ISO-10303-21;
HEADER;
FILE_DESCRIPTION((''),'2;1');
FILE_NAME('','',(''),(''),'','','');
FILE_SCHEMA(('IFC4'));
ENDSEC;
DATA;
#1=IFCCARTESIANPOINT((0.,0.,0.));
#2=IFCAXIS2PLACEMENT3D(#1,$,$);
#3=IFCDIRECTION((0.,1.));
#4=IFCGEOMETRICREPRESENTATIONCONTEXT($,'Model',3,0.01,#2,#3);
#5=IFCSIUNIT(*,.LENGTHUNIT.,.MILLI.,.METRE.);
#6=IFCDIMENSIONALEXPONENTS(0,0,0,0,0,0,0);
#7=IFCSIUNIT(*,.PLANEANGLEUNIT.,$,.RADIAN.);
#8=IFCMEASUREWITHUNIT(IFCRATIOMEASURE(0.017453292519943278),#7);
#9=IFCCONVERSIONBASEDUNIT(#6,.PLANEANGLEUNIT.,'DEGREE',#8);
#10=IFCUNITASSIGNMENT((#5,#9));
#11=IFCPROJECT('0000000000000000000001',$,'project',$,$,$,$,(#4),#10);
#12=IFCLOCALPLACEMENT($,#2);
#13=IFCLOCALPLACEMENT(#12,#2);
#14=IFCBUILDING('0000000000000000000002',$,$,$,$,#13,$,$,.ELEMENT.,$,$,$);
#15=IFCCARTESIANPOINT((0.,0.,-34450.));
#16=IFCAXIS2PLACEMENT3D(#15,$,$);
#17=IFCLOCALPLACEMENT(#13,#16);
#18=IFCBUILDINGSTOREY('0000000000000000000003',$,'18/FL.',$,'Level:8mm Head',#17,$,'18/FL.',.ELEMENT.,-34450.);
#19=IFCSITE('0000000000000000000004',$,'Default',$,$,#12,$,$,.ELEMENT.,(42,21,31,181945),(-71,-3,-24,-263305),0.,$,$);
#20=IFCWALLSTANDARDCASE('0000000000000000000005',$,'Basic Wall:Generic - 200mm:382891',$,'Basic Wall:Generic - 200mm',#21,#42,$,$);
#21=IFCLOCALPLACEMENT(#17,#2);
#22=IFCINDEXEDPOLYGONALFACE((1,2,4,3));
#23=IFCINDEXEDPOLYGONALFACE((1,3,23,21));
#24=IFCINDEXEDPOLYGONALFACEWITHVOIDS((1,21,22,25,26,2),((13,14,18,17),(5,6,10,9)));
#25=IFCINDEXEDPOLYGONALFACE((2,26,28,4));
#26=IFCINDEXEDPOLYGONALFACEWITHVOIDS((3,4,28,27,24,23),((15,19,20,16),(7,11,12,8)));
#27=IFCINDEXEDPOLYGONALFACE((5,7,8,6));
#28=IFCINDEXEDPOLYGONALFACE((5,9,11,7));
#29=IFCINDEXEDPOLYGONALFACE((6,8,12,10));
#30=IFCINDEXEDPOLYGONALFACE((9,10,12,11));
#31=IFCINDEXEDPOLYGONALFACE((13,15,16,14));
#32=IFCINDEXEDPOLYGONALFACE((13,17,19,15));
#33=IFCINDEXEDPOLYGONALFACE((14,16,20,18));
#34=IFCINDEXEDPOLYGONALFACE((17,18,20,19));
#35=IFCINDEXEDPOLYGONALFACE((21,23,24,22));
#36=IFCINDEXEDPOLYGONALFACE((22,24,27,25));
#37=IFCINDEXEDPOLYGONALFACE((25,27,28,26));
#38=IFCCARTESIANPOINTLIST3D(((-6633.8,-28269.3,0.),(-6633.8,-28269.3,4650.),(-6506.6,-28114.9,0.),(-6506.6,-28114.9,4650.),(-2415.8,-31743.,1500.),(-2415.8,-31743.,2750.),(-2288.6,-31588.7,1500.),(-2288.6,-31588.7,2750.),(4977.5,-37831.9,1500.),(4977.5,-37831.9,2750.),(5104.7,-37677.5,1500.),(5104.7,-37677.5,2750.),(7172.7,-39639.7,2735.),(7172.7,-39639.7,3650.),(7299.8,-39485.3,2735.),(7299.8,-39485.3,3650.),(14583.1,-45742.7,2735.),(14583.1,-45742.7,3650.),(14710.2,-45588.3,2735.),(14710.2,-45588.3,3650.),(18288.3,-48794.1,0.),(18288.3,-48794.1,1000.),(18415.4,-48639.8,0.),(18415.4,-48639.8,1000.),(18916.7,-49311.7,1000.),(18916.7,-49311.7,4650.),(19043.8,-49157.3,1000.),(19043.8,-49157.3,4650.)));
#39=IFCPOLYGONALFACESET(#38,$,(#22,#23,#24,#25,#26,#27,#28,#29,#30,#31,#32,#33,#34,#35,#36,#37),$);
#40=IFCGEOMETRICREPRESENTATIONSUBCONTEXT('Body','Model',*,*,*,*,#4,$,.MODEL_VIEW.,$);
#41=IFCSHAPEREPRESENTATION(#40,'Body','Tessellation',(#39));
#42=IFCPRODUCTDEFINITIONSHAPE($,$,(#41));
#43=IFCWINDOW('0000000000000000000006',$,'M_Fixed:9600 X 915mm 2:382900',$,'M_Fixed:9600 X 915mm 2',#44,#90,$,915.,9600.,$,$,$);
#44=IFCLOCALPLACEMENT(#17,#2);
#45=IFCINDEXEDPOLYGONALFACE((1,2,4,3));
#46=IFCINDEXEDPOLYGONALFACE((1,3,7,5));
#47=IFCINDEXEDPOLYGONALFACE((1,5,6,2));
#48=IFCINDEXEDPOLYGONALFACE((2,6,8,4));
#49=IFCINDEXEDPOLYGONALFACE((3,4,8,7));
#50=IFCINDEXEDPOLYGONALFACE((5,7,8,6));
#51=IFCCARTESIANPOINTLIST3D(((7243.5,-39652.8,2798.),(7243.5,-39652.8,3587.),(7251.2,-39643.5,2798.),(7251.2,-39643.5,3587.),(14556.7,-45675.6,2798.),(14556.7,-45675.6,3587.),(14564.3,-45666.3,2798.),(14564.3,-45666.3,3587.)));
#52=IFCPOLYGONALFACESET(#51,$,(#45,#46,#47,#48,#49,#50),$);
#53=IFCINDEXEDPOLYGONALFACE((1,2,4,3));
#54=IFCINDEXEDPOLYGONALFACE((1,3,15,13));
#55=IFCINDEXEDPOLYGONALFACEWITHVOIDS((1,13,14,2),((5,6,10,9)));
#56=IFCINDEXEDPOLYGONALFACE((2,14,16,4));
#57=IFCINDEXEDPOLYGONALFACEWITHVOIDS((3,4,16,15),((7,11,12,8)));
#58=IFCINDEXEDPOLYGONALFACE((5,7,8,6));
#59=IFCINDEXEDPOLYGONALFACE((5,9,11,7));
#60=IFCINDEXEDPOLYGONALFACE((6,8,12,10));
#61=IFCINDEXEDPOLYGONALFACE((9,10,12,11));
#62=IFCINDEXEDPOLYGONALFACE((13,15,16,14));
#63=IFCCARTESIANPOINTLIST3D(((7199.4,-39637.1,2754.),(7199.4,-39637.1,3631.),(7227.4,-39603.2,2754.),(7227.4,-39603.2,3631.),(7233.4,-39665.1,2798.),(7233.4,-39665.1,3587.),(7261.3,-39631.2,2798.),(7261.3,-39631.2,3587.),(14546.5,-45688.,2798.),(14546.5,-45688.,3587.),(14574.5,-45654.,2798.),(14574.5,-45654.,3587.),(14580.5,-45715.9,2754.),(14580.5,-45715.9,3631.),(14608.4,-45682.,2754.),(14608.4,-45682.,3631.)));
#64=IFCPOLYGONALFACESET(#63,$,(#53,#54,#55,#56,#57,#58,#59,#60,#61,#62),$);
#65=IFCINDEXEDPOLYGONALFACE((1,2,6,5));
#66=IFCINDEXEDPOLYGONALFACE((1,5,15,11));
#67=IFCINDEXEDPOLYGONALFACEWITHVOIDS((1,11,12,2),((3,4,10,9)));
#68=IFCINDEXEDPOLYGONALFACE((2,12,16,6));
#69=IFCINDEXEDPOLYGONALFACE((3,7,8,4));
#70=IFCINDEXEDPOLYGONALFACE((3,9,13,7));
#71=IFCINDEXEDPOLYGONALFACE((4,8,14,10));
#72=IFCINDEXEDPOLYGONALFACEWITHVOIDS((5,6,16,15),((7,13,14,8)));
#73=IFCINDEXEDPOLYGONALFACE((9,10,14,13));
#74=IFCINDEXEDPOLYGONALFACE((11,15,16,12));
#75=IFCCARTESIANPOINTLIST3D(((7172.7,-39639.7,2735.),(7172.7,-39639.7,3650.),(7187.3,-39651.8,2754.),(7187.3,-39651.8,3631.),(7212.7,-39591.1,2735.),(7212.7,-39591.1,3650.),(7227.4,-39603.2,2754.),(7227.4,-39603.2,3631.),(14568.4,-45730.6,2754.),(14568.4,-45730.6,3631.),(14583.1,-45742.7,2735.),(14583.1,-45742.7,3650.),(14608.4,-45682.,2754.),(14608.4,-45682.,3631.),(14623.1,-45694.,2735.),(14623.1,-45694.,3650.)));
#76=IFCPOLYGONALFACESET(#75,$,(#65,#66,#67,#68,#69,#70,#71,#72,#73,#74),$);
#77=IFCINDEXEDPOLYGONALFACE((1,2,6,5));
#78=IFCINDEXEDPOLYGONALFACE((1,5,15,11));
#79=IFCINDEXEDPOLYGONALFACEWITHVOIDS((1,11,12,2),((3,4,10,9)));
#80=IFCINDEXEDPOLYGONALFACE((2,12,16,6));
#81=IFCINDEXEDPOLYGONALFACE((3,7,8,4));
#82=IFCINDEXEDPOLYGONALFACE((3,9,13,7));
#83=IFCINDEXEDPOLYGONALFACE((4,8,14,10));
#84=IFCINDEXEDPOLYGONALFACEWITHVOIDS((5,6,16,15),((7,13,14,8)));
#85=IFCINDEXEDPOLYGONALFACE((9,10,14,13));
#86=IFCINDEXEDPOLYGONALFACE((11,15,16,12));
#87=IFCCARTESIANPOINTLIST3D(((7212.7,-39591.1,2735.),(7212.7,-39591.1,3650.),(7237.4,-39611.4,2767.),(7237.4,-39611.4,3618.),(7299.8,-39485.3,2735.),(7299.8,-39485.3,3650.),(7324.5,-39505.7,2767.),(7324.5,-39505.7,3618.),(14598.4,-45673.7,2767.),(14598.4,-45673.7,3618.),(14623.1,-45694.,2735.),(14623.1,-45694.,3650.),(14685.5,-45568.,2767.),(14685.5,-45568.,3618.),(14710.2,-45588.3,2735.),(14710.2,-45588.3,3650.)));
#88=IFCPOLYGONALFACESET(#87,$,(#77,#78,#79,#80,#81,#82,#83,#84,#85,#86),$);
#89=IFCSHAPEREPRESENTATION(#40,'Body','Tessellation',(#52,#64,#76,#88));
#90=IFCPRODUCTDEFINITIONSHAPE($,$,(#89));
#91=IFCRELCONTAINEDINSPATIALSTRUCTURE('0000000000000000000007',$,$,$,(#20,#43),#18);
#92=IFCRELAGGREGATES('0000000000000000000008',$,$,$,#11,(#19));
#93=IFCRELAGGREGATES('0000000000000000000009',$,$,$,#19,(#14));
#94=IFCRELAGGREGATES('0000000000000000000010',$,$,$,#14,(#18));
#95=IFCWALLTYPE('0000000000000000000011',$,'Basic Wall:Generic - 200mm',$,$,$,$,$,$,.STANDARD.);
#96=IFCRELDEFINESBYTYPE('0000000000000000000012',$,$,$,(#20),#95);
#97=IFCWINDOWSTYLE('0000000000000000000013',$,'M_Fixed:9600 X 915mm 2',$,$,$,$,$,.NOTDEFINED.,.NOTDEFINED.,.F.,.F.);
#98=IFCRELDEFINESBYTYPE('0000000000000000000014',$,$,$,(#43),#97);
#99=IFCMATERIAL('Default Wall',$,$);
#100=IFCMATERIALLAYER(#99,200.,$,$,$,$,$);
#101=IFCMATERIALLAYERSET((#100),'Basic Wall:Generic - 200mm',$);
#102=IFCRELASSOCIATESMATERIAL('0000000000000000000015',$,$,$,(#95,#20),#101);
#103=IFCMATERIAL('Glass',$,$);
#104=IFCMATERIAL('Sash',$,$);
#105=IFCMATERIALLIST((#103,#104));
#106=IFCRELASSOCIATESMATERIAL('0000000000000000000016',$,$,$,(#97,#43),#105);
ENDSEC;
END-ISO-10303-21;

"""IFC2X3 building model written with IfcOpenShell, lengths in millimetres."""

from ifc_helpers import new_model, entity, si_unit, converted_unit, direction, frame, frame_2d, origin, place, context, subcontext, project, spatial, polyline, rectangle, outline, extrude, source, transform, mapped, material, material_list, layer, layer_set, layer_usage, type_object, type_shapes, element, fill, save


model = new_model("IFC2X3")

# Units and contexts
model_context = context("Model", 3, precision=0.01, world=origin(), true_north=direction((0.0, 1.0)))
body_context = subcontext(model_context, "Body", "Model", "MODEL_VIEW")
ifc_project = project(units=[si_unit("LENGTHUNIT", "METRE", prefix="MILLI"), converted_unit("PLANEANGLEUNIT", "DEGREE", entity("IfcRatioMeasure", 0.017453292519943278), si_unit("PLANEANGLEUNIT", "RADIAN"), dimensions=[0, 0, 0, 0, 0, 0, 0])], contexts=[model_context])

# Site, building, storey
site_placement = place(None, origin())
site = spatial("IfcSite", under=ifc_project, at=site_placement, Name="Default", CompositionType="ELEMENT", RefLatitude=(42, 21, 31, 181945), RefLongitude=(-71, -3, -24, -263305), RefElevation=0.0)
building_placement = place(site_placement, origin())
building = spatial("IfcBuilding", under=site, at=building_placement, CompositionType="ELEMENT")
storey_placement = place(building_placement, frame((0.0, 0.0, -34450.0)))
storey = spatial("IfcBuildingStorey", under=building, at=storey_placement, Name="18/FL.", ObjectType="Level:8mm Head", LongName="18/FL.", CompositionType="ELEMENT", Elevation=-34450.0)

# Shared definitions
ifc_material_1 = material(Name="Default Wall")
ifc_layer = layer(ifc_material_1, 200.0)
ifc_layer_set = layer_set([ifc_layer], Name="Basic Wall:Generic - 200mm")
ifc_layer_usage = layer_usage(ifc_layer_set, "AXIS2", "NEGATIVE", 100.0)
wall_type = type_object("IfcWallType", Name="Basic Wall:Generic - 200mm", PredefinedType="STANDARD", material=ifc_layer_set)

# Shared definitions
ifc_material_2 = material(Name="Glass")
ifc_material_3 = material(Name="Sash")
ifc_material_list = material_list([ifc_material_2, ifc_material_3])

# Wall, openings, window
wall_1_placement = place(storey_placement, frame((-6570.2, -28192.1, 0.0), z_axis=(0.0, 0.0, 1.0), x_axis=(0.771917, -0.635723, 0.0)))
wall_1 = element("IfcWallStandardCase", 1, at=wall_1_placement, inside=storey, type_object=wall_type, material=ifc_layer_usage, Name="Basic Wall:Generic - 200mm:382891", ObjectType="Basic Wall:Generic - 200mm", context=body_context, shape_type="SweptSolid", body=[
    extrude(rectangle(XDim=33100.0, YDim=200.0, at=frame_2d((16550.0, 0.0), x_axis=(-1.0, 0.0))), origin(), (0.0, 0.0, 1.0), 4650.0),
])
opening_1_placement = place(wall_1_placement, origin())
element("IfcOpeningElement", 2, at=opening_1_placement, cuts=wall_1, ObjectType="Opening", context=body_context, shape_type="SweptSolid", body=[
    extrude(rectangle(XDim=1250.0, YDim=9577.8, at=frame_2d((0.0, 0.0), x_axis=(1.0, 0.0))), frame((10253.2, -100.0, 2125.0), z_axis=(0.0, 1.0, 0.0), x_axis=(0.0, 0.0, -1.0)), (0.0, 0.0, 1.0), 200.0),
])
opening_2_placement = place(wall_1_placement, frame((-12850.7, 25938.8, 0.0), z_axis=(0.0, 0.0, 1.0), x_axis=(0.771917, 0.635723, 0.0)))
element("IfcOpeningElement", 3, at=opening_2_placement, cuts=wall_1, ObjectType="Opening", context=body_context, shape_type="SweptSolid", body=[
    extrude(rectangle(XDim=1000.0, YDim=1010.1, at=frame_2d((0.0, 0.0), x_axis=(1.0, 0.0))), frame((18670.0, -49125.0, 500.0), z_axis=(0.635723, 0.771917, 0.0), x_axis=(0.0, 0.0, -1.0)), (0.0, 0.0, 1.0), 1012.7),
])
opening_3_placement = place(wall_1_placement, frame((27485.9, 100.0, 2735.0)))
opening_3 = element("IfcOpeningElement", 4, at=opening_3_placement, cuts=wall_1, ObjectType="Opening", context=body_context, shape_type="SweptSolid", body=[
    extrude(rectangle(XDim=915.0, YDim=9600.0, at=frame_2d((457.5, 4800.0), x_axis=(1.0, 0.0))), frame((0.0, 0.0, 0.0), z_axis=(0.0, -1.0, 0.0), x_axis=(0.0, 0.0, 1.0)), (0.0, 0.0, 1.0), 200.0),
])
window_style_1 = type_object("IfcWindowStyle", Name="M_Fixed:9600 X 915mm 2", ConstructionType="NOTDEFINED", OperationType="NOTDEFINED", ParameterTakesPrecedence=False, Sizeable=False, material=ifc_material_list)
shared_shape_1 = source(origin(), body_context, "Body", "SweptSolid", [
    extrude(rectangle(XDim=12.0, YDim=9474.0, at=frame_2d((0.0, 0.0), x_axis=(1.0, 0.0))), frame((4800.0, 159.0, 63.0), z_axis=(0.0, 0.0, 1.0), x_axis=(0.0, -1.0, 0.0)), (0.0, 0.0, 1.0), 789.0),
    extrude(outline(polyline([(-4781.0, -438.5), (4781.0, -438.5), (4781.0, 438.5), (-4781.0, 438.5), (-4781.0, -438.5)]), holes=[polyline([(-4737.0, -394.5), (-4737.0, 394.5), (4737.0, 394.5), (4737.0, -394.5), (-4737.0, -394.5)])]), frame((4800.0, 137.0, 457.5), z_axis=(0.0, 1.0, 0.0), x_axis=(1.0, 0.0, 0.0)), (0.0, 0.0, 1.0), 44.0),
    extrude(outline(polyline([(-4800.0, -457.5), (4800.0, -457.5), (4800.0, 457.5), (-4800.0, 457.5), (-4800.0, -457.5)]), holes=[polyline([(-4781.0, -438.5), (-4781.0, 438.5), (4781.0, 438.5), (4781.0, -438.5), (-4781.0, -438.5)])]), frame((4800.0, 137.0, 457.5), z_axis=(0.0, 1.0, 0.0), x_axis=(1.0, 0.0, 0.0)), (0.0, 0.0, 1.0), 63.0),
    extrude(outline(polyline([(-4800.0, -457.5), (4800.0, -457.5), (4800.0, 457.5), (-4800.0, 457.5), (-4800.0, -457.5)]), holes=[polyline([(-4768.0, -425.5), (-4768.0, 425.5), (4768.0, 425.5), (4768.0, -425.5), (-4768.0, -425.5)])]), frame((4800.0, 0.0, 457.5), z_axis=(0.0, 1.0, 0.0), x_axis=(1.0, 0.0, 0.0)), (0.0, 0.0, 1.0), 137.0),
])
type_shapes(window_style_1, [shared_shape_1])
window_1_placement = place(opening_3_placement, frame((0.0, 0.0, 0.0), z_axis=(0.0, 0.0, 1.0), x_axis=(-1.0, 0.0, 0.0)))
window_1 = element("IfcWindow", 5, at=window_1_placement, inside=storey, type_object=window_style_1, material=ifc_material_list, Name="M_Fixed:9600 X 915mm 2:382900", ObjectType="M_Fixed:9600 X 915mm 2", OverallHeight=915.0, OverallWidth=9600.0, context=body_context, shape_type="MappedRepresentation", body=[
    mapped(shared_shape_1, transform((0.0, 0.0, 0.0), scale=1.0)),
])
fill(opening_3, window_1)

save(model, "model.ifc")
